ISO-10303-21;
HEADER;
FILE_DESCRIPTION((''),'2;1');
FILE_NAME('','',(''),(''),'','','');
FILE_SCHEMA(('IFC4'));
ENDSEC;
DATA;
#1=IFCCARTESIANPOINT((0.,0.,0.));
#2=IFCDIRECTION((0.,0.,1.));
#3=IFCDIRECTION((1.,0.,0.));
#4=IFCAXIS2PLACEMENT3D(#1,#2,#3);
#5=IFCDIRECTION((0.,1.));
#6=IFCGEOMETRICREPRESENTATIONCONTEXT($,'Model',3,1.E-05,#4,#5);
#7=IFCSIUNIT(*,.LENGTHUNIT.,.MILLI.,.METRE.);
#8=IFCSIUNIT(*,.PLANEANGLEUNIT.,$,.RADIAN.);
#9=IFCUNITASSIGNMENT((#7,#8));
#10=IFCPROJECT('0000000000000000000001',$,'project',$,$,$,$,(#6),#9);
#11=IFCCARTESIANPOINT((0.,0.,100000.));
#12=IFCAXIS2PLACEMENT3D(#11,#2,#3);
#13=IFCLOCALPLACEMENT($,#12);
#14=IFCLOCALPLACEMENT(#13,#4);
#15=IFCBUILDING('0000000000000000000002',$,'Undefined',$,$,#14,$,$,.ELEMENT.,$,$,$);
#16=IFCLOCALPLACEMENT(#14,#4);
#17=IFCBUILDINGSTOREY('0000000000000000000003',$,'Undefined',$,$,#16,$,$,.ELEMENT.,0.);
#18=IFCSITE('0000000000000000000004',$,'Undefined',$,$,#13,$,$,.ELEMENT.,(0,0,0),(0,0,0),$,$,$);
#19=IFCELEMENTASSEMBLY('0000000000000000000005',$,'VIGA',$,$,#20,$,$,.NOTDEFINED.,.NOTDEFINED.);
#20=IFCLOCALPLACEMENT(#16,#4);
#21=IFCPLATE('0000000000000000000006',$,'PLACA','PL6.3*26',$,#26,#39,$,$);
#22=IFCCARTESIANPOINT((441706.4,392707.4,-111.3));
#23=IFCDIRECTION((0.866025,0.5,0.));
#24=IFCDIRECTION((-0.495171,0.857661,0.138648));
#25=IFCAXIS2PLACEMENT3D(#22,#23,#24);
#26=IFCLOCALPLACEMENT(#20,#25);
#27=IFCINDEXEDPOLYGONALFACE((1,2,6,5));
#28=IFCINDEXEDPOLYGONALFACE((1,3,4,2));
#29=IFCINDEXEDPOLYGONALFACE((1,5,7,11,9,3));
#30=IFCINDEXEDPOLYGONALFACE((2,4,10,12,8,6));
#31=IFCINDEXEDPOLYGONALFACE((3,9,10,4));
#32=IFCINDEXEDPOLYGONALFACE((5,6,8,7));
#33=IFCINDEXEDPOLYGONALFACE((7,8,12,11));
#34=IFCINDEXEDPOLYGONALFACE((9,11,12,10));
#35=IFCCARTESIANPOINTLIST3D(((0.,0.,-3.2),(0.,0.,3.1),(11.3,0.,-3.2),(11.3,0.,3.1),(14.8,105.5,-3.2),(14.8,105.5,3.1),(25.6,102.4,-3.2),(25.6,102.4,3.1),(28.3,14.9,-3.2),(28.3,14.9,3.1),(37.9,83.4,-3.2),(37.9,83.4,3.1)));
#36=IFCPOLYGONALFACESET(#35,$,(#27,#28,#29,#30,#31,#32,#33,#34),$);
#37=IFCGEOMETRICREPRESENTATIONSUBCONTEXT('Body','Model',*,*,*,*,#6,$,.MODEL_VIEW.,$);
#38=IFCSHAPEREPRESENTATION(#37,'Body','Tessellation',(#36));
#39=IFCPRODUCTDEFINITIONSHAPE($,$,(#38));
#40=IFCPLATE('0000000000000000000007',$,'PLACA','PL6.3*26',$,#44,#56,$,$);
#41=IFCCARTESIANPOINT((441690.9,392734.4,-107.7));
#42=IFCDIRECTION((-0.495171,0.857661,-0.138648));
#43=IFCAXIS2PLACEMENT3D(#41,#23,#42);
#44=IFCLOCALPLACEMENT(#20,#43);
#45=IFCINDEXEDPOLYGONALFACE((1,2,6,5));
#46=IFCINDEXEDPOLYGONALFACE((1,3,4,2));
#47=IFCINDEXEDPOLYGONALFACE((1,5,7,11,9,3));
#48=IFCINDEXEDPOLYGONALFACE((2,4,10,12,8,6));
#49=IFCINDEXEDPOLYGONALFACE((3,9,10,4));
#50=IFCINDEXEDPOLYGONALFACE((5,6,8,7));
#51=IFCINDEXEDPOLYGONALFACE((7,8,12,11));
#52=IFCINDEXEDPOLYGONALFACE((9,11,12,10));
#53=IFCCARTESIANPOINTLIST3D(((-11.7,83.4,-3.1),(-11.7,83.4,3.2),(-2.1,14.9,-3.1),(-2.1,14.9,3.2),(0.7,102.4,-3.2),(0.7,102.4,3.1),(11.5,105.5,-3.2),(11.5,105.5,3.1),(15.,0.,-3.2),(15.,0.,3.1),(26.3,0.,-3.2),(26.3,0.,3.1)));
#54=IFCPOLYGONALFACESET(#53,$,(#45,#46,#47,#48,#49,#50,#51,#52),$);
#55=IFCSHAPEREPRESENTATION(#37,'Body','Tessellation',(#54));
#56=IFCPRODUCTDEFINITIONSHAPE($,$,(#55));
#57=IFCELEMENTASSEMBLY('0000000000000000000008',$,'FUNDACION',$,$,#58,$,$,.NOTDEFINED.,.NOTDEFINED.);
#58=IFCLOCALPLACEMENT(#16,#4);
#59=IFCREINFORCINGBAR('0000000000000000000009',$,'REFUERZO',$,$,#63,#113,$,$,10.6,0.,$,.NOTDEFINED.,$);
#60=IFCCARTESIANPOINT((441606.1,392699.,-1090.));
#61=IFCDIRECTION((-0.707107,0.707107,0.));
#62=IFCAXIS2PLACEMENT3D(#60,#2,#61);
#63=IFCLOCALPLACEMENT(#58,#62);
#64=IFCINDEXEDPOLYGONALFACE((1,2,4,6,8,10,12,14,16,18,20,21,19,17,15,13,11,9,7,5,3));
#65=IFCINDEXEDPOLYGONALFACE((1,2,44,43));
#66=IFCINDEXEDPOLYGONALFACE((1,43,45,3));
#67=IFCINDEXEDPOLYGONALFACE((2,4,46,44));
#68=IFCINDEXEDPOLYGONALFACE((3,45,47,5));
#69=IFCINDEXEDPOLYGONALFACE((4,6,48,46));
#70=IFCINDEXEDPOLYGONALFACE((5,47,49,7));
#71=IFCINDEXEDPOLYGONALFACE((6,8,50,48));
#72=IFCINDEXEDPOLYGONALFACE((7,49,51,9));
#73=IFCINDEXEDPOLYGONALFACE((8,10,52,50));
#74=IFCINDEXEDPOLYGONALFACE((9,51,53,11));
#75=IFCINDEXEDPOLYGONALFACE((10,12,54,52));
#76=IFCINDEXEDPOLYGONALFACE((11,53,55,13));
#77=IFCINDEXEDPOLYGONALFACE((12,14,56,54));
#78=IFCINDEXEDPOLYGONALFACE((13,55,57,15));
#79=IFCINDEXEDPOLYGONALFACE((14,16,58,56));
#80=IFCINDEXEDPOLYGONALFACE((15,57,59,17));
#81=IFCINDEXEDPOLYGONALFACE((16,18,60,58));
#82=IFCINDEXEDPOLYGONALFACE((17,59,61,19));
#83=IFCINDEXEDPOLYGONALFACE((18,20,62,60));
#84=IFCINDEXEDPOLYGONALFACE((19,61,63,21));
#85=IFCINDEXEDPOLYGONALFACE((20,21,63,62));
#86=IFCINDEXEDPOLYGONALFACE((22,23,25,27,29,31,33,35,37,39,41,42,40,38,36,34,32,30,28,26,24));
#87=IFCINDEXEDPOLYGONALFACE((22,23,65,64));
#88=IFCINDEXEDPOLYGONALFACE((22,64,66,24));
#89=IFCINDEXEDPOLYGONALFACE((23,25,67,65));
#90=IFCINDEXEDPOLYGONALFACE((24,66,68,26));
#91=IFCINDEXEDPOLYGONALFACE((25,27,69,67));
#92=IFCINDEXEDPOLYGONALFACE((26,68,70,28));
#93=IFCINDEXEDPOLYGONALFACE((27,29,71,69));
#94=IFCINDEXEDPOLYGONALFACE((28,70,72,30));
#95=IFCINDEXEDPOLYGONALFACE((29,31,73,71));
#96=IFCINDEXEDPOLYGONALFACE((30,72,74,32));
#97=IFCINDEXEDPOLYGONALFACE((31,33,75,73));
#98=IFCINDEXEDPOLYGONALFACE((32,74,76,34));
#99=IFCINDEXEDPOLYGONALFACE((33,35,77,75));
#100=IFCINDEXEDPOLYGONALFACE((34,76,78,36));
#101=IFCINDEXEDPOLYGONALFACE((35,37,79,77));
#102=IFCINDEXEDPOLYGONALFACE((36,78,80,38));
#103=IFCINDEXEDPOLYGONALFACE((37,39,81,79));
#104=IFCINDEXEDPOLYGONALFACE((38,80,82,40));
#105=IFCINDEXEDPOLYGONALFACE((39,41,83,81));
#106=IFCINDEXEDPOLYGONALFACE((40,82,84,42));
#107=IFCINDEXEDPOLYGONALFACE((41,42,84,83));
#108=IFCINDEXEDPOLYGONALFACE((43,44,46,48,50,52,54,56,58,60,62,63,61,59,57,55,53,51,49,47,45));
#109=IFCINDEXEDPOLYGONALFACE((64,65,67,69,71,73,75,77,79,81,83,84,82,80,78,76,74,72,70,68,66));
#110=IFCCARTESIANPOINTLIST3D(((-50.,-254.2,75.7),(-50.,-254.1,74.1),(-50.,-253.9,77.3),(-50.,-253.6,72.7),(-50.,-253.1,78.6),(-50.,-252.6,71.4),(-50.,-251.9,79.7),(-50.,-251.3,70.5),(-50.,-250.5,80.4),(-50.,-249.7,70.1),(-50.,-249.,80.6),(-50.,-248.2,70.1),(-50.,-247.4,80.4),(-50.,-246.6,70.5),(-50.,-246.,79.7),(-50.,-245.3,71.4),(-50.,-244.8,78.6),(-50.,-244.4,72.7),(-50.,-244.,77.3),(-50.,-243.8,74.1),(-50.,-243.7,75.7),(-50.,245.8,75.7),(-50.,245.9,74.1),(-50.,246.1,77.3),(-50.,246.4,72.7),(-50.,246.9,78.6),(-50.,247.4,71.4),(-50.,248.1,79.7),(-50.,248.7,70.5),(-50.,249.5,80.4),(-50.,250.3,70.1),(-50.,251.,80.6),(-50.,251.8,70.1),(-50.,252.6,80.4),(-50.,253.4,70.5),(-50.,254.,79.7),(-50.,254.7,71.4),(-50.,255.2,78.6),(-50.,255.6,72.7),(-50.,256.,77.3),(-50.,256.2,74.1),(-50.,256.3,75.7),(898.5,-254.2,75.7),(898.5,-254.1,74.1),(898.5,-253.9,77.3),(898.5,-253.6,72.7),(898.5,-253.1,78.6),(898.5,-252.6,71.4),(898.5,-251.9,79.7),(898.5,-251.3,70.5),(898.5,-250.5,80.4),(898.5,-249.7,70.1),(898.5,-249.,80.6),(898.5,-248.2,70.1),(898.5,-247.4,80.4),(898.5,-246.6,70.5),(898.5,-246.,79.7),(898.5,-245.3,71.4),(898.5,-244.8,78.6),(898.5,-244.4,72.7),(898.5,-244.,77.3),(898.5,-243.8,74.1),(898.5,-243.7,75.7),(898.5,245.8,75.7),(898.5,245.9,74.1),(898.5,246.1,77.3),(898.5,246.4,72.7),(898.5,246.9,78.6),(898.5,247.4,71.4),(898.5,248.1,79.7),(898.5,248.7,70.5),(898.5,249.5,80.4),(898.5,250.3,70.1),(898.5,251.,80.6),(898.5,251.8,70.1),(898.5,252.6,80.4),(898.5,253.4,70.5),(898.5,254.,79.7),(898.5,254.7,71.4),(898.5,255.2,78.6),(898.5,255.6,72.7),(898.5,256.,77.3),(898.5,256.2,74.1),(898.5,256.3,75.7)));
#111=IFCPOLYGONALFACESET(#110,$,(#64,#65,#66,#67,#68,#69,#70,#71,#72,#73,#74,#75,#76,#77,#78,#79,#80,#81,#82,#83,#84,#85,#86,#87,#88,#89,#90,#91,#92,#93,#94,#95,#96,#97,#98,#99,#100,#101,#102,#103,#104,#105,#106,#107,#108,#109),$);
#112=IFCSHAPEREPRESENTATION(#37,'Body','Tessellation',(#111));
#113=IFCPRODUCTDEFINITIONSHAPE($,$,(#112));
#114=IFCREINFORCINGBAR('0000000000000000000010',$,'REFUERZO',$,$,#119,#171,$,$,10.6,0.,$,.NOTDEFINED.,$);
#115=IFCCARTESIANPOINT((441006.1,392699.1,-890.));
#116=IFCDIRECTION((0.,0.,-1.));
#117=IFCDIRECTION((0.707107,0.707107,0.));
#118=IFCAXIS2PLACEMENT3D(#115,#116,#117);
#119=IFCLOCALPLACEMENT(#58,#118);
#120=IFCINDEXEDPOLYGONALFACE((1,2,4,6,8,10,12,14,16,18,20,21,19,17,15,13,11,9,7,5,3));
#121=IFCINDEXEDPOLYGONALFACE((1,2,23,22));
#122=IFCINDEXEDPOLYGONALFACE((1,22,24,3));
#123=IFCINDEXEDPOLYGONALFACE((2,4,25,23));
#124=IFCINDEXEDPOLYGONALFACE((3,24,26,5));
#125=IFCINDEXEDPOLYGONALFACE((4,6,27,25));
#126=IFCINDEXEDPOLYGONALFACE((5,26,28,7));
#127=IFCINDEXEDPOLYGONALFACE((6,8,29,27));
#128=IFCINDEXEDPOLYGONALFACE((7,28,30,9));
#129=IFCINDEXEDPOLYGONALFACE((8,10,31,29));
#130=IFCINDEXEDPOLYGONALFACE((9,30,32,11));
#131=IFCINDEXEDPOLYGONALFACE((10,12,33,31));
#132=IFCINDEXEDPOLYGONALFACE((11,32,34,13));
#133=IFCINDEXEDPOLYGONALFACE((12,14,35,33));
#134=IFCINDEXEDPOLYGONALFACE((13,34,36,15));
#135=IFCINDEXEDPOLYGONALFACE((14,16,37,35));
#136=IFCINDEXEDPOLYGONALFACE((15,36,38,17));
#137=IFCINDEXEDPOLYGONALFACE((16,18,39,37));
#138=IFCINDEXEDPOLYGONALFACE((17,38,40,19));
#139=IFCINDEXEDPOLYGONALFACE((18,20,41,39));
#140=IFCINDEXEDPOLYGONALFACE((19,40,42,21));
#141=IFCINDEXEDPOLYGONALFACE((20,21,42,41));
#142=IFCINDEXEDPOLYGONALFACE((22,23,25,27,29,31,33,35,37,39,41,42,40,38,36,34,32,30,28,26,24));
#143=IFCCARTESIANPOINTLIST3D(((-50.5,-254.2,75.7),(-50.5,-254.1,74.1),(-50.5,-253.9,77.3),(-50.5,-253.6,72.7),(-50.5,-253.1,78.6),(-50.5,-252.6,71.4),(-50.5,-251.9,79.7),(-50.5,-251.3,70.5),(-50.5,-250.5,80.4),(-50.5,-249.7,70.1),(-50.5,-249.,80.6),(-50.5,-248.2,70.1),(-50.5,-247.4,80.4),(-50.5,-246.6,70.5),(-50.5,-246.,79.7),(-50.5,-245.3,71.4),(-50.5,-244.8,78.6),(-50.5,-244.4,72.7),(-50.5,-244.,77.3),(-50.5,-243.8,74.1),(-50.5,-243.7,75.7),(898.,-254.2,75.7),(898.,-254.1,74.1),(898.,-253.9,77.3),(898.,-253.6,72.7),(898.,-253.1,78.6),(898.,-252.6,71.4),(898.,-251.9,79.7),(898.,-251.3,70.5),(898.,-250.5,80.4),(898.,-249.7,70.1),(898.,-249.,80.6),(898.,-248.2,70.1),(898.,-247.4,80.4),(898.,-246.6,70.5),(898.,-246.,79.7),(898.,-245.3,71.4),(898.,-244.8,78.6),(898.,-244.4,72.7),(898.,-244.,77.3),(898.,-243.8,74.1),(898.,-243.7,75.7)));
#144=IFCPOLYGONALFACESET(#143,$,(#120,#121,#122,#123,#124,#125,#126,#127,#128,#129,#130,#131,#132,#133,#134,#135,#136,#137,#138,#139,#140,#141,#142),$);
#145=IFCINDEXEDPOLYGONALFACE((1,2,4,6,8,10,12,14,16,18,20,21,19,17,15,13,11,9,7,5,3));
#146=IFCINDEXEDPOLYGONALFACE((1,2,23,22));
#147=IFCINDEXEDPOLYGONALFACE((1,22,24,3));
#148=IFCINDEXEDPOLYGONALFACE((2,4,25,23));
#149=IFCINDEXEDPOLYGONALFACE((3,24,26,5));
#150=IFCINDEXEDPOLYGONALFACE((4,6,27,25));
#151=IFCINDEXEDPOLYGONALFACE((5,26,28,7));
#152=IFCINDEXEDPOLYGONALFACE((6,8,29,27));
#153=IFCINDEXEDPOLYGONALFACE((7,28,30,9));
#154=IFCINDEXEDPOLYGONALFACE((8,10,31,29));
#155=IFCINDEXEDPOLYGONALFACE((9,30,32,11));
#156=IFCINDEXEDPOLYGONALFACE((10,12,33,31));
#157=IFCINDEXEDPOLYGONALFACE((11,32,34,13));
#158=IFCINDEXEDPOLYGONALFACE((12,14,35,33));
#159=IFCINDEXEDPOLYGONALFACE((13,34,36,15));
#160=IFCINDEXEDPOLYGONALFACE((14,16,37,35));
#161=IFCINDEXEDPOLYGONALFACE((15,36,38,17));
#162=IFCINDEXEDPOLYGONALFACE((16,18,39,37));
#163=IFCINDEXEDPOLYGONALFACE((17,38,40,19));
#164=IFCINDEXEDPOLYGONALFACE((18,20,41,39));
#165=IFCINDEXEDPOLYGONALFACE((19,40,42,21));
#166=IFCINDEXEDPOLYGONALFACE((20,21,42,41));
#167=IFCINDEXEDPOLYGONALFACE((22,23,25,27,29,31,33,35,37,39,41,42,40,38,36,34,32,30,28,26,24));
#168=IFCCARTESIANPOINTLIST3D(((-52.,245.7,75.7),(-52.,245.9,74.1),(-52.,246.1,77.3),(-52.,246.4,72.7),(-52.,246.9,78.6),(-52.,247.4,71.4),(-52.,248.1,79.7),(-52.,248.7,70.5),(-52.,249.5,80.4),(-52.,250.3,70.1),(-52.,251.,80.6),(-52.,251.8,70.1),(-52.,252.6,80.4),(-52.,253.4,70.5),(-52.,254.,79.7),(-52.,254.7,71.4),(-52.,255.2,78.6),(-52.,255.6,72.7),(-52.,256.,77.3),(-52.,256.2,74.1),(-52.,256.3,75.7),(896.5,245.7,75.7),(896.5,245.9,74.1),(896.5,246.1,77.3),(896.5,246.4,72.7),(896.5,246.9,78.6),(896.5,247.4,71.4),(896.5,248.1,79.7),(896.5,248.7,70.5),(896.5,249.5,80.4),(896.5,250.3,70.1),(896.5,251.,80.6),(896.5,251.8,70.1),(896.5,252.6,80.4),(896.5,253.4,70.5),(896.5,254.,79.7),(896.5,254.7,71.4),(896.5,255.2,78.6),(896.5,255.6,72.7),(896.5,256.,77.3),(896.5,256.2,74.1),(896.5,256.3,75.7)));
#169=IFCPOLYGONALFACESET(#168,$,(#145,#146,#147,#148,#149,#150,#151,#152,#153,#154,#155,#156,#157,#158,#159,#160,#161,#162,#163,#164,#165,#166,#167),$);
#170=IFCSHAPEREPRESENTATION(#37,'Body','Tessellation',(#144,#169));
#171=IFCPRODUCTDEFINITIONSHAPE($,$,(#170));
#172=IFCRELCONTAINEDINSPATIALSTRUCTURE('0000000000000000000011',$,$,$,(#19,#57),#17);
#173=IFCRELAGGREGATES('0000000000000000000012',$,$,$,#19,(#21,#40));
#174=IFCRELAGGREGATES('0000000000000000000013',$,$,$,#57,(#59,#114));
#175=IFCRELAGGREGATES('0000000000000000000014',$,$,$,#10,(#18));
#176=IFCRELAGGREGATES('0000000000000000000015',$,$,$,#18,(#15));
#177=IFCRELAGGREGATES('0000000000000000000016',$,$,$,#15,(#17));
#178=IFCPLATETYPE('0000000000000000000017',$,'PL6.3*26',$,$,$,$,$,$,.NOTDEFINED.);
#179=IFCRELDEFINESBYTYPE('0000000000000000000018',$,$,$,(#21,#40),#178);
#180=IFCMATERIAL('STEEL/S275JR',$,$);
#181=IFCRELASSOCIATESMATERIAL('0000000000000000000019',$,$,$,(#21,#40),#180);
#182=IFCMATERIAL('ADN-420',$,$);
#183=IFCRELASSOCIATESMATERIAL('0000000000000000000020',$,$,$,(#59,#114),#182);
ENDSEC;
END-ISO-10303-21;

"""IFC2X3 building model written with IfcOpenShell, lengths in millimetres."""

from ifc_helpers import new_model, entity, si_unit, direction, frame, origin_with_axes, place, context, subcontext, project, spatial, polyline, outline, extrude, source, transform, mapped, material, type_object, element, aggregate, save


model = new_model("IFC2X3")

# Units and contexts
model_context = context("Model", 3, precision=1e-05, world=origin_with_axes(), true_north=direction((0.0, 1.0)))
body_context = subcontext(model_context, "Body", "Model", "MODEL_VIEW")
ifc_project = project(units=[si_unit("LENGTHUNIT", "METRE", prefix="MILLI"), si_unit("PLANEANGLEUNIT", "RADIAN")], contexts=[model_context])

# Site, building, storey
site_placement = place(None, frame((0.0, 0.0, 100000.0), z_axis=(0.0, 0.0, 1.0), x_axis=(1.0, 0.0, 0.0)))
site = spatial("IfcSite", under=ifc_project, at=site_placement, Name="Undefined", CompositionType="ELEMENT", RefLatitude=(0, 0, 0), RefLongitude=(0, 0, 0))
building_placement = place(site_placement, origin_with_axes())
building = spatial("IfcBuilding", under=site, at=building_placement, Name="Undefined", CompositionType="ELEMENT")
storey_placement = place(building_placement, origin_with_axes())
storey = spatial("IfcBuildingStorey", under=building, at=storey_placement, Name="Undefined", CompositionType="ELEMENT", Elevation=0.0)

# Shared definitions
ifc_material_1 = material(Name="STEEL/S275JR")

# Element assembly
assembly_1_placement = place(storey_placement, origin_with_axes())
assembly_1 = element("IfcElementAssembly", 1, at=assembly_1_placement, inside=storey, Name="VIGA", AssemblyPlace="NOTDEFINED", PredefinedType="NOTDEFINED")

# Plates
plate_type_1 = type_object("IfcPlateType", Name="PL6.3*26", PredefinedType="NOTDEFINED")
plate_1_placement = place(assembly_1_placement, frame((441706.4, 392707.4, -111.3), z_axis=(0.866025, 0.5, 0.0), x_axis=(-0.495171, 0.857661, 0.138648)))
plate_1 = element("IfcPlate", 2, at=plate_1_placement, type_object=plate_type_1, material=ifc_material_1, Name="PLACA", Description="PL6.3*26", context=body_context, shape_type="SweptSolid", body=[
    extrude(outline(polyline([(0.0, 0.0), (11.3, 0.0), (28.3, 14.9), (37.9, 83.4), (25.6, 102.4), (14.8, 105.5), (0.0, 0.0)])), frame((0.0, 0.0, -3.1), z_axis=(0.0, 0.0, 1.0), x_axis=(1.0, 0.0, 0.0)), (0.0, 0.0, 1.0), 6.3),
])
plate_2_placement = place(assembly_1_placement, frame((441690.9, 392734.4, -107.7), z_axis=(0.866025, 0.5, 0.0), x_axis=(-0.495171, 0.857661, -0.138648)))
plate_2 = element("IfcPlate", 3, at=plate_2_placement, type_object=plate_type_1, material=ifc_material_1, Name="PLACA", Description="PL6.3*26", context=body_context, shape_type="SweptSolid", body=[
    extrude(outline(polyline([(-2.1, 14.9), (15.0, 0.0), (26.3, 0.0), (11.5, 105.5), (0.7, 102.4), (-11.7, 83.4), (-2.1, 14.9)])), frame((0.0, 0.0, -3.1), z_axis=(0.0, 0.0, 1.0), x_axis=(1.0, 0.0, 0.0)), (0.0, 0.0, 1.0), 6.3),
])
aggregate(assembly_1, [plate_1, plate_2])

# Element assembly, reinforcing bars
assembly_2_placement = place(storey_placement, origin_with_axes())
assembly_2 = element("IfcElementAssembly", 4, at=assembly_2_placement, inside=storey, Name="FUNDACION", AssemblyPlace="NOTDEFINED", PredefinedType="NOTDEFINED")
ifc_material_2 = material(Name="ADN-420")
shared_shape_1 = source(origin_with_axes(), body_context, "Body", "AdvancedSweptSolid", [
    entity("IfcSweptDiskSolid", entity("IfcTrimmedCurve", entity("IfcLine", entity("IfcCartesianPoint", [0.0, 0.0, 0.0]), entity("IfcVector", entity("IfcDirection", [1.0, 0.0, 0.0]), 1.0)), [entity("IfcParameterValue", 0.0)], [entity("IfcParameterValue", 948.528137)], True, "PARAMETER"), 5.3, None, 0.0, 948.5),
])
shared_shape_2 = source(origin_with_axes(), body_context, "Body", "AdvancedSweptSolid", [
    entity("IfcSweptDiskSolid", entity("IfcTrimmedCurve", entity("IfcLine", entity("IfcCartesianPoint", [0.0, 0.0, 0.0]), entity("IfcVector", entity("IfcDirection", [1.0, 0.0, 0.0]), 1.0)), [entity("IfcParameterValue", 0.0)], [entity("IfcParameterValue", 948.528137)], True, "PARAMETER"), 5.3, None, 0.0, 948.5),
])
reinforcing_bar_1_placement = place(assembly_2_placement, frame((441606.1, 392699.0, -1090.0), z_axis=(0.0, 0.0, 1.0), x_axis=(-0.707107, 0.707107, 0.0)))
reinforcing_bar_1 = element("IfcReinforcingBar", 5, at=reinforcing_bar_1_placement, material=ifc_material_2, Name="REFUERZO", BarRole="NOTDEFINED", CrossSectionArea=0.0, NominalDiameter=10.6, context=body_context, shape_type="MappedRepresentation", body=[
    mapped(shared_shape_1, transform((-50.0, -249.0, 75.3))),
    mapped(shared_shape_2, transform((-50.0, 251.0, 75.3))),
])
shared_shape_3 = source(origin_with_axes(), body_context, "Body", "AdvancedSweptSolid", [
    entity("IfcSweptDiskSolid", entity("IfcTrimmedCurve", entity("IfcLine", entity("IfcCartesianPoint", [0.0, 0.0, 0.0]), entity("IfcVector", entity("IfcDirection", [1.0, 0.0, 0.0]), 1.0)), [entity("IfcParameterValue", 0.0)], [entity("IfcParameterValue", 948.528137)], True, "PARAMETER"), 5.3, None, 0.0, 948.5),
])
shared_shape_4 = source(origin_with_axes(), body_context, "Body", "AdvancedSweptSolid", [
    entity("IfcSweptDiskSolid", entity("IfcTrimmedCurve", entity("IfcLine", entity("IfcCartesianPoint", [0.0, 0.0, 0.0]), entity("IfcVector", entity("IfcDirection", [1.0, 0.0, 0.0]), 1.0)), [entity("IfcParameterValue", 0.0)], [entity("IfcParameterValue", 948.528137)], True, "PARAMETER"), 5.3, None, 0.0, 948.5),
])
reinforcing_bar_2_placement = place(assembly_2_placement, frame((441006.1, 392699.1, -890.0), z_axis=(0.0, 0.0, -1.0), x_axis=(0.707107, 0.707107, 0.0)))
reinforcing_bar_2 = element("IfcReinforcingBar", 6, at=reinforcing_bar_2_placement, material=ifc_material_2, Name="REFUERZO", BarRole="NOTDEFINED", CrossSectionArea=0.0, NominalDiameter=10.6, context=body_context, shape_type="MappedRepresentation", body=[
    mapped(shared_shape_3, transform((-50.5, -249.0, 75.3))),
    mapped(shared_shape_4, transform((-52.0, 251.0, 75.3))),
])
aggregate(assembly_2, [reinforcing_bar_1, reinforcing_bar_2])

save(model, "model.ifc")
